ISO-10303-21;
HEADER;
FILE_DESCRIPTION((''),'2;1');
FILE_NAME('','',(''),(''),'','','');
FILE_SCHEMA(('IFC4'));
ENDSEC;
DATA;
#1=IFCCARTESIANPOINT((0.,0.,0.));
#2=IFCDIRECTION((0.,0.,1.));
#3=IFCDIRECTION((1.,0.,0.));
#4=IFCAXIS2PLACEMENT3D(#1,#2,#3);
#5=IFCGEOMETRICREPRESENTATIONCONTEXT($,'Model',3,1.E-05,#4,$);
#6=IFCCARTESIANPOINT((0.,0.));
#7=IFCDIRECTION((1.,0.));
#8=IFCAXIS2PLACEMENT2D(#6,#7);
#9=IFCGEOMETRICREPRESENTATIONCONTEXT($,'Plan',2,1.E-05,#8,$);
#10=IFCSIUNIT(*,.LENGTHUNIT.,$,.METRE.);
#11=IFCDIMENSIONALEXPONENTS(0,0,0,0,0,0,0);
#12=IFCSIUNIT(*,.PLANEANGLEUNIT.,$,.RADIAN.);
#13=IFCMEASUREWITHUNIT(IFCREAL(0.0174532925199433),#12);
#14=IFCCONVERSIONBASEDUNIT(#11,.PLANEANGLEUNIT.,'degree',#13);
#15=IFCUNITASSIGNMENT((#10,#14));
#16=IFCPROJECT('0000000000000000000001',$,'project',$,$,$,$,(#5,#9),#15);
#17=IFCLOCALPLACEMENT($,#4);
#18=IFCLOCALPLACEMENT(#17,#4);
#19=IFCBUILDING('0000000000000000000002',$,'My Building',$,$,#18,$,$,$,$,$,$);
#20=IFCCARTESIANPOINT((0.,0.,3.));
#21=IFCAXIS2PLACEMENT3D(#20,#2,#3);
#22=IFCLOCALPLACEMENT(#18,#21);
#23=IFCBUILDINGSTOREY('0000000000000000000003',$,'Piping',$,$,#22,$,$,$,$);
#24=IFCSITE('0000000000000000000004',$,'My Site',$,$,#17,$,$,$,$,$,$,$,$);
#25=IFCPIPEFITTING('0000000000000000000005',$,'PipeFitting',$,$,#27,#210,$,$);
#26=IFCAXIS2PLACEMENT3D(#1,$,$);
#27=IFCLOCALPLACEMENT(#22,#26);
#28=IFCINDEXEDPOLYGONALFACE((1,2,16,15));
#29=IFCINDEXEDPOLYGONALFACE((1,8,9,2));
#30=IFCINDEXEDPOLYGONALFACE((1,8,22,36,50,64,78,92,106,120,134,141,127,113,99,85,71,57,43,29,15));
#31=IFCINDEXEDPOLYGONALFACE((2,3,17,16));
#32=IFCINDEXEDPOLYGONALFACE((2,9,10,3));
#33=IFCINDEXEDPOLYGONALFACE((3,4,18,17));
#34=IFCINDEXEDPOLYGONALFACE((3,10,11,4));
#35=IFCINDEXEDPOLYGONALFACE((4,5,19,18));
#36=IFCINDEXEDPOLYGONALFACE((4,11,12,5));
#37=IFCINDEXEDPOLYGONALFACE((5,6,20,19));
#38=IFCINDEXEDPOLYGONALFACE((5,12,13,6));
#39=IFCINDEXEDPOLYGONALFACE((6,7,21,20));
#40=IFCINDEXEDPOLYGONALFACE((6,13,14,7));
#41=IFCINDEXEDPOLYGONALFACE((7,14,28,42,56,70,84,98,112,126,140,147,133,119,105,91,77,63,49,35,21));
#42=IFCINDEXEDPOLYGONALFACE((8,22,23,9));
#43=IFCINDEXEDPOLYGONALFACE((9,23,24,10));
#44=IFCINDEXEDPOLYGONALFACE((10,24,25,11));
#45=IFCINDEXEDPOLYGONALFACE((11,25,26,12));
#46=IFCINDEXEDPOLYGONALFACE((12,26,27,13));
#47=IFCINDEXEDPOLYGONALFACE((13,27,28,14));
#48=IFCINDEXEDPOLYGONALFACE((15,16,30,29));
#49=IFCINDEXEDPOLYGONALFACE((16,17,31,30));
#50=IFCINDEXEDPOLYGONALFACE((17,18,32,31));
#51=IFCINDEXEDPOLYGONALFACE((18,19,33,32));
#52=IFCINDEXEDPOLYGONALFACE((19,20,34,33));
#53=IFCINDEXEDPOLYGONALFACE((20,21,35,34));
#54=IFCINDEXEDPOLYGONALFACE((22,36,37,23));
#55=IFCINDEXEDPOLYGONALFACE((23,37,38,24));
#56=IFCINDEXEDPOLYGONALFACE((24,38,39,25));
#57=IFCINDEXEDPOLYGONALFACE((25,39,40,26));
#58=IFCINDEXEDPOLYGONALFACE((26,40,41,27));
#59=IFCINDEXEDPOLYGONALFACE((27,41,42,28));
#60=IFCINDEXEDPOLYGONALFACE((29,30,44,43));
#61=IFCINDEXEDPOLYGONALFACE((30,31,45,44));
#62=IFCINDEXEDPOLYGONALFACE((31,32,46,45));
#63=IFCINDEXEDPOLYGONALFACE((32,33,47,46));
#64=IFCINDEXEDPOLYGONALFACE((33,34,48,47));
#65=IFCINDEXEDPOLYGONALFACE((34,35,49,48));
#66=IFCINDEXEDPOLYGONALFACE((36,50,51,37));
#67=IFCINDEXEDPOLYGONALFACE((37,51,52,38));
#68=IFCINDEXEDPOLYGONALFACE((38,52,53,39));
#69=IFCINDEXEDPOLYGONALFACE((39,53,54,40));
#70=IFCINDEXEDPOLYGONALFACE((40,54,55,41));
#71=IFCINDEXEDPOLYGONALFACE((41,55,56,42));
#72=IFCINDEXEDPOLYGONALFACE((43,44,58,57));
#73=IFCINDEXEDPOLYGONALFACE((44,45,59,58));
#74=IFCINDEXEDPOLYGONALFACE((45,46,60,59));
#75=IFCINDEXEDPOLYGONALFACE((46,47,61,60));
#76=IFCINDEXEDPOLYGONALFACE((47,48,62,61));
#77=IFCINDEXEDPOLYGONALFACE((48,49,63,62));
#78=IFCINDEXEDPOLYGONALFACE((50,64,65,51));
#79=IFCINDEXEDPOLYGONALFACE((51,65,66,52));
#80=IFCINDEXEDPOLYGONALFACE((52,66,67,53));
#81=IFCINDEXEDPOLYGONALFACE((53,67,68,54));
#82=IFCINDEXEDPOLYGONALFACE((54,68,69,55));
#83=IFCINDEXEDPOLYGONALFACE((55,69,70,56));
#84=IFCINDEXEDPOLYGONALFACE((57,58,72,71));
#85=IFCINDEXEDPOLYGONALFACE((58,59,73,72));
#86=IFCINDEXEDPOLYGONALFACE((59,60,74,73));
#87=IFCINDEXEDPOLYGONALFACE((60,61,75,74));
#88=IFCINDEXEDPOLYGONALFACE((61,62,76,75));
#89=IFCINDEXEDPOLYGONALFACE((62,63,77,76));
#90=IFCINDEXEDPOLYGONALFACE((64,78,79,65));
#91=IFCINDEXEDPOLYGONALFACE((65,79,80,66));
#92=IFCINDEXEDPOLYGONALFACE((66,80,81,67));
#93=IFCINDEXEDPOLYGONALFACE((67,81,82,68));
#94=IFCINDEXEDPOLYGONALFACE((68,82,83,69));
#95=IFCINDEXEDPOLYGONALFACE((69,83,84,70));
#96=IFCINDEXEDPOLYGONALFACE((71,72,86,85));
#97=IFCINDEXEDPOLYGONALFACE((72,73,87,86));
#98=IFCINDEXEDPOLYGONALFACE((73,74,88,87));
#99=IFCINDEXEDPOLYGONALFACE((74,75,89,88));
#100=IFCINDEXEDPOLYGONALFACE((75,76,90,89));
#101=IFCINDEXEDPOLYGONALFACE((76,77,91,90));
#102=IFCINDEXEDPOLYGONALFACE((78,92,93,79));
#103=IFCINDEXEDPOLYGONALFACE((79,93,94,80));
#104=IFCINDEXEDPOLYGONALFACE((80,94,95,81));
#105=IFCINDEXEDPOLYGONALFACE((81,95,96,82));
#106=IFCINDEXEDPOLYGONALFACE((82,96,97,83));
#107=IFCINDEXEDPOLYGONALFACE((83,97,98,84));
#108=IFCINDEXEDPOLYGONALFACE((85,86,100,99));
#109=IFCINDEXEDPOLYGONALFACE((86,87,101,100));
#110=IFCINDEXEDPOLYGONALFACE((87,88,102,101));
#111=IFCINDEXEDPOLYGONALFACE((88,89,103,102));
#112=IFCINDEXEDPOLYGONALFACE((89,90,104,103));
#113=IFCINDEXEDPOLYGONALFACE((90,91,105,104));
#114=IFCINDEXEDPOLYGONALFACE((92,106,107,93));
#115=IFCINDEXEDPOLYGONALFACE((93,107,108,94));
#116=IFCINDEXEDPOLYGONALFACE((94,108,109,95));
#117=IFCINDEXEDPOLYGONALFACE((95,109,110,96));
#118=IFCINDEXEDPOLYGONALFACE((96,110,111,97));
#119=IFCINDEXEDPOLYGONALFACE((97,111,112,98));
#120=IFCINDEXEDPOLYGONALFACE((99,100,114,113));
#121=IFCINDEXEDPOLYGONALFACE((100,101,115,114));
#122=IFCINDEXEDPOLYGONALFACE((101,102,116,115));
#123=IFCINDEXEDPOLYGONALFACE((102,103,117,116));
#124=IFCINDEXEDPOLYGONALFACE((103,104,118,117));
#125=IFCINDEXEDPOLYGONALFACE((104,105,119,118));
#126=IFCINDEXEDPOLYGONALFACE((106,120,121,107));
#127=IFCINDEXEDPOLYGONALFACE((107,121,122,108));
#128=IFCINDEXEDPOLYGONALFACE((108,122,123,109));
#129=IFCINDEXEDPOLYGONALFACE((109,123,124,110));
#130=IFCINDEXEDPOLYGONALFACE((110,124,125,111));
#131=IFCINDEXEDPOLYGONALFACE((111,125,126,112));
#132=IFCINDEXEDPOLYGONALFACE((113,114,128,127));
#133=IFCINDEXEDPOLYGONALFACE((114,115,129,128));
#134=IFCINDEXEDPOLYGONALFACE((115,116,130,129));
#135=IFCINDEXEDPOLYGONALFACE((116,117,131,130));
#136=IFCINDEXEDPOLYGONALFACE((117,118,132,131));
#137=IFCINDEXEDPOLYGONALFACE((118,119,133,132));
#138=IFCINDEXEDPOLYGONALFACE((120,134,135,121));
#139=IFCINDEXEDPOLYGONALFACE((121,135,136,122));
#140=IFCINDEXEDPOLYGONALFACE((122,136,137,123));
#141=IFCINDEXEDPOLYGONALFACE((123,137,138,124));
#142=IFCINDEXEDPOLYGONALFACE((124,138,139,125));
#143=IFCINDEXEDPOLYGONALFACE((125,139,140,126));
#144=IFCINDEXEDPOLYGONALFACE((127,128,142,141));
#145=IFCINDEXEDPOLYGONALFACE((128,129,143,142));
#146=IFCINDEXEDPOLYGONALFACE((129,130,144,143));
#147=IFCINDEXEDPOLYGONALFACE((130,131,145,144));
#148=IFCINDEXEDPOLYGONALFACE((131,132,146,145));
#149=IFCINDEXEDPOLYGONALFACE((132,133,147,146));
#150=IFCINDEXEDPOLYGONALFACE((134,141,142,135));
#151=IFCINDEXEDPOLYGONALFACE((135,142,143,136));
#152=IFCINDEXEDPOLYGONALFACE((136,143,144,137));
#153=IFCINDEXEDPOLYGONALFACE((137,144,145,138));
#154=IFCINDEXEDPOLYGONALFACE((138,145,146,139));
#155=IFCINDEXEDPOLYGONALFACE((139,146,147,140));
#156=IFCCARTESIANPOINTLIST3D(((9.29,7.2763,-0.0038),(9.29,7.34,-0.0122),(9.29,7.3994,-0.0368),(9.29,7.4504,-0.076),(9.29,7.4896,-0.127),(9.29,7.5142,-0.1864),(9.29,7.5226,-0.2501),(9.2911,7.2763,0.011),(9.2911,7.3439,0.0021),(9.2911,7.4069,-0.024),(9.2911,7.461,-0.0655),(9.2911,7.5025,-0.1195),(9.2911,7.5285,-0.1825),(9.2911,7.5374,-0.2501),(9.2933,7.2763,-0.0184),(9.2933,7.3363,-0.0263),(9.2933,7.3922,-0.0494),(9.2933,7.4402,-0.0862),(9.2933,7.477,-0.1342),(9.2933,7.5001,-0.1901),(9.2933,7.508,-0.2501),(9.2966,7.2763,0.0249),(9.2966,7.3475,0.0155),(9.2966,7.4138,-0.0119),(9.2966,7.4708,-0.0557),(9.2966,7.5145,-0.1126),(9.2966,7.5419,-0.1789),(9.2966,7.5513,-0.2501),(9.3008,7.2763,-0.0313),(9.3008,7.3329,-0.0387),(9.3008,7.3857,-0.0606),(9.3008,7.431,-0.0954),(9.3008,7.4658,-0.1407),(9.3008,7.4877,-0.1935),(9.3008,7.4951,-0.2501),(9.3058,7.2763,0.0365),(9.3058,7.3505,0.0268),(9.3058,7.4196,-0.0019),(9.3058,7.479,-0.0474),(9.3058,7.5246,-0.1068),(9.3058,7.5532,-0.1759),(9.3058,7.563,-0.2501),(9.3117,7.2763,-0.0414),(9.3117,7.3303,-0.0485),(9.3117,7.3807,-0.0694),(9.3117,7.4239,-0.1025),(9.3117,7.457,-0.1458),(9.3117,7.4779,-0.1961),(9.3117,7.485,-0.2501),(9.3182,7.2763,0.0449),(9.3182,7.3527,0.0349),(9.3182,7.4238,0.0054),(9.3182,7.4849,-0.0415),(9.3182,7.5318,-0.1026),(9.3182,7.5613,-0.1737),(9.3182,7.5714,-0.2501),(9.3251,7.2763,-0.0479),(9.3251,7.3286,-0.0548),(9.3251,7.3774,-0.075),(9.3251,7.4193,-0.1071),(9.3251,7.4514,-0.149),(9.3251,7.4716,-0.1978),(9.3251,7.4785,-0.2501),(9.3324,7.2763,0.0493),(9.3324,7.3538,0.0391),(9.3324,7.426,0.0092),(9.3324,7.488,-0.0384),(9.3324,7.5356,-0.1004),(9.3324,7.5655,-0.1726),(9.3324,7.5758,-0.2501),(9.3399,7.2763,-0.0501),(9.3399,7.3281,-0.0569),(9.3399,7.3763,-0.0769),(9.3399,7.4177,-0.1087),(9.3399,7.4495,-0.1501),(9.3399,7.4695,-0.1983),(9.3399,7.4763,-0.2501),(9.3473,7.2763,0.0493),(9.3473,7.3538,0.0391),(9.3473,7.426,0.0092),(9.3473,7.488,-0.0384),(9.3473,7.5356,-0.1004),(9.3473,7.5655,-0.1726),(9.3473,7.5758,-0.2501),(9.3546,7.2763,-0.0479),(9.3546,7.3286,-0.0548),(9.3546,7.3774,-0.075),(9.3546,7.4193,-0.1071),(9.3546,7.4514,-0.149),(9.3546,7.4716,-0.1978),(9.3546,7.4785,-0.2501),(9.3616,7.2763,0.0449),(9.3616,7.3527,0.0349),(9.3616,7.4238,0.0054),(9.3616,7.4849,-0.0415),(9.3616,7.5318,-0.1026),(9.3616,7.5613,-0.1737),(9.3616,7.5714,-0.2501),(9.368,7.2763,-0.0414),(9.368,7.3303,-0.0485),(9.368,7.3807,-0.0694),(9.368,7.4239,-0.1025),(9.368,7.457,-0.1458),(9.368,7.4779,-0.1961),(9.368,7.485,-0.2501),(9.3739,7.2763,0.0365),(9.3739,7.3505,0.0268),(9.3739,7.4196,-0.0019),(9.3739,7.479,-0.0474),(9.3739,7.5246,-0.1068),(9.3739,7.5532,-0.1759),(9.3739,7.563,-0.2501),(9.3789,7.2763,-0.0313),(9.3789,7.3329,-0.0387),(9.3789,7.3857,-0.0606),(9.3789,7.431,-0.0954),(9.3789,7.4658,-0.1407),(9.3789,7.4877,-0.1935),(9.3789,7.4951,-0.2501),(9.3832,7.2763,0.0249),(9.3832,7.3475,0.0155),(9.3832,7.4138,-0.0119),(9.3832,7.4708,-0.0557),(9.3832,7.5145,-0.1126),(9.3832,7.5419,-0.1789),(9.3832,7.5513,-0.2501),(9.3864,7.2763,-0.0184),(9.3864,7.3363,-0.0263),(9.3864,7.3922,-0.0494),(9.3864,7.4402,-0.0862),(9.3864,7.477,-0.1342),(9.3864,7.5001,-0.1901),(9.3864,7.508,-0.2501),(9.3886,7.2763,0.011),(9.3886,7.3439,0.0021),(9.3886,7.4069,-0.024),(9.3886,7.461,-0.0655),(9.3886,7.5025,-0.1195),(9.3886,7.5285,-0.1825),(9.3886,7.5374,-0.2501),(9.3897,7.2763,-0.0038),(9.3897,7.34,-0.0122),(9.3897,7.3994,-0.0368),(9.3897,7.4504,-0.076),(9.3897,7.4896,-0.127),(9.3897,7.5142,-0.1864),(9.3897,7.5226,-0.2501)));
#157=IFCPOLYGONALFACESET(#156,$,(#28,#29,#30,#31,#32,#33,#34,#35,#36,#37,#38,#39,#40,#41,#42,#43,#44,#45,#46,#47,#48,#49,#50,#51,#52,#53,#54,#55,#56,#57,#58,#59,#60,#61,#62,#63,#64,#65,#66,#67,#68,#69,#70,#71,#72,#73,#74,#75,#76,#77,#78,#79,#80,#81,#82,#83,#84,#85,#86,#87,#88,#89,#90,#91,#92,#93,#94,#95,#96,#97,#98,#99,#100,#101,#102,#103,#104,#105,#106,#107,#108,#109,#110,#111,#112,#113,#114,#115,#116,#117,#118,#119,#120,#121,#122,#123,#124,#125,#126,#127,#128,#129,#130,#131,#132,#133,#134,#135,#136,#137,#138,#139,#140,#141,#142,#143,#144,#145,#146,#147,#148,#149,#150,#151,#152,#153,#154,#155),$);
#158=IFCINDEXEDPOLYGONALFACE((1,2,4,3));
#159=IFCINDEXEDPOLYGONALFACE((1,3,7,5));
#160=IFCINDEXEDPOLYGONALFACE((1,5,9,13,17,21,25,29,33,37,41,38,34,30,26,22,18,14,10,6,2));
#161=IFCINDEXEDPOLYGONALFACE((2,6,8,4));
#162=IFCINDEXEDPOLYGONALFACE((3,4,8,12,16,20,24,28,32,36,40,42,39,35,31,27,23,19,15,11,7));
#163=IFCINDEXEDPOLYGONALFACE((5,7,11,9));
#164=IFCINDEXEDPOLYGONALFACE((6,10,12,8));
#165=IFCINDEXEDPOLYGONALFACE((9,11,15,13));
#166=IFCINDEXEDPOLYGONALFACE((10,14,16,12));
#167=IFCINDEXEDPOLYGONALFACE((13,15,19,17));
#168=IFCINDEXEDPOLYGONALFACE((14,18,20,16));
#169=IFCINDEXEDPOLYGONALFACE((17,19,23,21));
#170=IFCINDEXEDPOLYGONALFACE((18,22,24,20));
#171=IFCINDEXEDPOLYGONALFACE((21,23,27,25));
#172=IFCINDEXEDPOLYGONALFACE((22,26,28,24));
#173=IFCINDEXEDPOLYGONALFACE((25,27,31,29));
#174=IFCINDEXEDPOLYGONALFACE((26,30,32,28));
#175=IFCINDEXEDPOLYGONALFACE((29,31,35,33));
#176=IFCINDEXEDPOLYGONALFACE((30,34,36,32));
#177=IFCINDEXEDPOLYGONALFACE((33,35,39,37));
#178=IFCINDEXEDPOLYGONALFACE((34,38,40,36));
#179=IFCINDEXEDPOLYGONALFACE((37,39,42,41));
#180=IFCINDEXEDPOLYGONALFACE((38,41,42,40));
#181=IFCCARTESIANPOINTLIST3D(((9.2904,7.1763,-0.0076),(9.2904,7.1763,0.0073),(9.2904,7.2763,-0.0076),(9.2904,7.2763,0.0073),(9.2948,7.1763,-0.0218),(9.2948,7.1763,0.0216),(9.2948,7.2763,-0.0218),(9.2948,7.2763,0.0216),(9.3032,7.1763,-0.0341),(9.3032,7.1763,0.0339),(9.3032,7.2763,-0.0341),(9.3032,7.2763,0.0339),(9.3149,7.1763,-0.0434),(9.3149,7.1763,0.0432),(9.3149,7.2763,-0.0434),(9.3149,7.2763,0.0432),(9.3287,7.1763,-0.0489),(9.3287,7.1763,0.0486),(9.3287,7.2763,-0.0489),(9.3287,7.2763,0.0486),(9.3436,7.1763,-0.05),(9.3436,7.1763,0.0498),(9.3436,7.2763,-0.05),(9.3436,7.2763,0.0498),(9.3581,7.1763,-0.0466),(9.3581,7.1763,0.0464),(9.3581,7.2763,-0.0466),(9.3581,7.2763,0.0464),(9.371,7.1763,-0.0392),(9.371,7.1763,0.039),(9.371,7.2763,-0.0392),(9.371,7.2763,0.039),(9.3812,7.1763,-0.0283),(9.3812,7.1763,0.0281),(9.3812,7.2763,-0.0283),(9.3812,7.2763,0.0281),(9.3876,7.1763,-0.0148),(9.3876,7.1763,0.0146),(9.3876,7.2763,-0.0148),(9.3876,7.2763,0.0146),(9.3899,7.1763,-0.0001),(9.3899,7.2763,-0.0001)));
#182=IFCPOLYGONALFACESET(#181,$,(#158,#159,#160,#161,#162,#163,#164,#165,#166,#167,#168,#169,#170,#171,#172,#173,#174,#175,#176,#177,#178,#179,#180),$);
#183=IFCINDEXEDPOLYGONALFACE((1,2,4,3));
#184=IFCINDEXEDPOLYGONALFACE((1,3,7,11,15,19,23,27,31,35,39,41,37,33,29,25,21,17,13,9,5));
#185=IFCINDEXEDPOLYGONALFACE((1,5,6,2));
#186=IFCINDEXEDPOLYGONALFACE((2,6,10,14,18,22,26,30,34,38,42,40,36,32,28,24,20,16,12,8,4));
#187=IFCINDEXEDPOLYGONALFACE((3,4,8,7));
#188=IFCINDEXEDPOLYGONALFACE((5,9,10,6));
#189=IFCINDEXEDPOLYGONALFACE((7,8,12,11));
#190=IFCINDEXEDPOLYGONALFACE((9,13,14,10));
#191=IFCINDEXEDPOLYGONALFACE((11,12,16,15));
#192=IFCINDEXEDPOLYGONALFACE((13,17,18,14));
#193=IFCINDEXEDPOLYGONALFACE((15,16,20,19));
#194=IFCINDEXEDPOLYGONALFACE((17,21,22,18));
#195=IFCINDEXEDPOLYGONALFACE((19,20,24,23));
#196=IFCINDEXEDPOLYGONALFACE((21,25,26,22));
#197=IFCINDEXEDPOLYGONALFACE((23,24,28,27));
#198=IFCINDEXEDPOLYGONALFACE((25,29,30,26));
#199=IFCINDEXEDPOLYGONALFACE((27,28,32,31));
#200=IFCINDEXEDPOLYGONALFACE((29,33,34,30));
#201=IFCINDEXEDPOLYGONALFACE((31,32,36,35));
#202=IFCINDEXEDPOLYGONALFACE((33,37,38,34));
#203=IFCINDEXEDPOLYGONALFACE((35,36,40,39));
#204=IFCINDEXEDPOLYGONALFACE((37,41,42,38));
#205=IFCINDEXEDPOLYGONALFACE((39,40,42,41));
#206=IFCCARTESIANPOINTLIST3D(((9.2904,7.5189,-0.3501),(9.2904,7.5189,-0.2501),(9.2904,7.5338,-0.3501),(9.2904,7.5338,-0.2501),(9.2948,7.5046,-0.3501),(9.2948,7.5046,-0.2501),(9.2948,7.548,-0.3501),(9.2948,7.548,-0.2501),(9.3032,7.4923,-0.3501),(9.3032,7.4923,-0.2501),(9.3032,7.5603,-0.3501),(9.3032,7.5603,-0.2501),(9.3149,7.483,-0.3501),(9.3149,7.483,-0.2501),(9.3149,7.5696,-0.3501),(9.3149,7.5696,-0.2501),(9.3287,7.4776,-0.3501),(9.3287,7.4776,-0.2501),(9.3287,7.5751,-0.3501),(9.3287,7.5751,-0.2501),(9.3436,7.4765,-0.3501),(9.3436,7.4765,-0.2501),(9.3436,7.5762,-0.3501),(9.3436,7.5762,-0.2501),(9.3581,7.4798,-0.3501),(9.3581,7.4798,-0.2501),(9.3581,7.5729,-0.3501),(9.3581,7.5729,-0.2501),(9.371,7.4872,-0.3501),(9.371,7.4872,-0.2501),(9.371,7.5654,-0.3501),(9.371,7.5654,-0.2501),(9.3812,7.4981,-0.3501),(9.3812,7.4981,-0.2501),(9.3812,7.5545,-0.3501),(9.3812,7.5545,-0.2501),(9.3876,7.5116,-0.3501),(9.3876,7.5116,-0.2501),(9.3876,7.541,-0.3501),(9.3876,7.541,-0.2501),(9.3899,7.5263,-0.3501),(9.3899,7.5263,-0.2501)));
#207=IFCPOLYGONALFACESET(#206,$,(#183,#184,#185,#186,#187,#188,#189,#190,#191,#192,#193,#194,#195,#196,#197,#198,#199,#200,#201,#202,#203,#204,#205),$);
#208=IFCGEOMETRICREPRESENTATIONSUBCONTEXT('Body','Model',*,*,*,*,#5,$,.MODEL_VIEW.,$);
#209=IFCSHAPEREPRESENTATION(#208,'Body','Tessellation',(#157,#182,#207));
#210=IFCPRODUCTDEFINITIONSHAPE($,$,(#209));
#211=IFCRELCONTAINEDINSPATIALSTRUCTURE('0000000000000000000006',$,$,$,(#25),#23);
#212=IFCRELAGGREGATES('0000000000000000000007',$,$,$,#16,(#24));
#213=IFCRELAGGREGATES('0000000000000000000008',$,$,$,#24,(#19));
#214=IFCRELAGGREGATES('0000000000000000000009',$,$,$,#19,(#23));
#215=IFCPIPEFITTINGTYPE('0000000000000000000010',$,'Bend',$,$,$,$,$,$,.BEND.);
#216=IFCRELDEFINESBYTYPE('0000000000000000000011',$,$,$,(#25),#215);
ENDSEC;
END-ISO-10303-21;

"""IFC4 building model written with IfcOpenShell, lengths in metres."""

from ifc_helpers import new_model, entity, si_unit, converted_unit, frame, origin_with_axes, origin_2d_with_axis, place, context, subcontext, project, spatial, circle, extrude, source, transform, mapped, type_object, type_shapes, element, save


model = new_model("IFC4")

# Units and contexts
model_context = context("Model", 3, precision=1e-05, world=origin_with_axes())
plan_context = context("Plan", 2, precision=1e-05, world=origin_2d_with_axis())
body_context = subcontext(model_context, "Body", "Model", "MODEL_VIEW")
ifc_project = project(units=[si_unit("LENGTHUNIT", "METRE"), converted_unit("PLANEANGLEUNIT", "degree", entity("IfcReal", 0.0174532925199433), si_unit("PLANEANGLEUNIT", "RADIAN"), dimensions=[0, 0, 0, 0, 0, 0, 0])], contexts=[model_context, plan_context])

# Site, building, storey
site_placement = place(None, origin_with_axes())
site = spatial("IfcSite", under=ifc_project, at=site_placement, Name="My Site")
building_placement = place(site_placement, origin_with_axes())
building = spatial("IfcBuilding", under=site, at=building_placement, Name="My Building")
storey_placement = place(building_placement, frame((0.0, 0.0, 3.0), z_axis=(0.0, 0.0, 1.0), x_axis=(1.0, 0.0, 0.0)))
storey = spatial("IfcBuildingStorey", under=building, at=storey_placement, Name="Piping")

# Pipe fitting
pipe_fitting_type = type_object("IfcPipeFittingType", Name="Bend", PredefinedType="BEND")
shared_shape = source(origin_with_axes(), body_context, "Body", "SolidModel", [
    entity("IfcSweptDiskSolid", entity("IfcIndexedPolyCurve", entity("IfcCartesianPointList3D", [[0.0, 0.0, -0.1], [0.0, -0.0732, -0.2768], [0.0, -0.25, -0.35]]), [entity("IfcArcIndex", [1, 2, 3])]), 0.05),
    extrude(circle(Radius=0.05), origin_with_axes(), (0.0, 0.0, -1.0), 0.1),
    extrude(circle(Radius=0.05), frame((0.0, -0.25, -0.35), z_axis=(0.0, -1.0, 0.0), x_axis=(1.0, 0.0, 0.0)), (0.0, 0.0, 1.0), 0.1),
])
type_shapes(pipe_fitting_type, [shared_shape])
for number, where, z_axis, x_axis, name in (
    (1, (9.3399, 7.1763, -0.0001), (0.0, -1.0, 0.0), (1.0, 0.0, 0.0), "PipeFitting"),
):
    element("IfcPipeFitting", number, at=place(storey_placement, frame(where, z_axis=z_axis, x_axis=x_axis)), inside=storey, type_object=pipe_fitting_type, Name=name, context=body_context, shape_type="MappedRepresentation", body=[
        mapped(shared_shape, transform((0.0, 0.0, 0.0), x_axis=(1.0, 0.0, 0.0), y_axis=(0.0, 1.0, 0.0), z_axis=(0.0, 0.0, 1.0), scale=1.0)),
    ])

save(model, "model.ifc")
